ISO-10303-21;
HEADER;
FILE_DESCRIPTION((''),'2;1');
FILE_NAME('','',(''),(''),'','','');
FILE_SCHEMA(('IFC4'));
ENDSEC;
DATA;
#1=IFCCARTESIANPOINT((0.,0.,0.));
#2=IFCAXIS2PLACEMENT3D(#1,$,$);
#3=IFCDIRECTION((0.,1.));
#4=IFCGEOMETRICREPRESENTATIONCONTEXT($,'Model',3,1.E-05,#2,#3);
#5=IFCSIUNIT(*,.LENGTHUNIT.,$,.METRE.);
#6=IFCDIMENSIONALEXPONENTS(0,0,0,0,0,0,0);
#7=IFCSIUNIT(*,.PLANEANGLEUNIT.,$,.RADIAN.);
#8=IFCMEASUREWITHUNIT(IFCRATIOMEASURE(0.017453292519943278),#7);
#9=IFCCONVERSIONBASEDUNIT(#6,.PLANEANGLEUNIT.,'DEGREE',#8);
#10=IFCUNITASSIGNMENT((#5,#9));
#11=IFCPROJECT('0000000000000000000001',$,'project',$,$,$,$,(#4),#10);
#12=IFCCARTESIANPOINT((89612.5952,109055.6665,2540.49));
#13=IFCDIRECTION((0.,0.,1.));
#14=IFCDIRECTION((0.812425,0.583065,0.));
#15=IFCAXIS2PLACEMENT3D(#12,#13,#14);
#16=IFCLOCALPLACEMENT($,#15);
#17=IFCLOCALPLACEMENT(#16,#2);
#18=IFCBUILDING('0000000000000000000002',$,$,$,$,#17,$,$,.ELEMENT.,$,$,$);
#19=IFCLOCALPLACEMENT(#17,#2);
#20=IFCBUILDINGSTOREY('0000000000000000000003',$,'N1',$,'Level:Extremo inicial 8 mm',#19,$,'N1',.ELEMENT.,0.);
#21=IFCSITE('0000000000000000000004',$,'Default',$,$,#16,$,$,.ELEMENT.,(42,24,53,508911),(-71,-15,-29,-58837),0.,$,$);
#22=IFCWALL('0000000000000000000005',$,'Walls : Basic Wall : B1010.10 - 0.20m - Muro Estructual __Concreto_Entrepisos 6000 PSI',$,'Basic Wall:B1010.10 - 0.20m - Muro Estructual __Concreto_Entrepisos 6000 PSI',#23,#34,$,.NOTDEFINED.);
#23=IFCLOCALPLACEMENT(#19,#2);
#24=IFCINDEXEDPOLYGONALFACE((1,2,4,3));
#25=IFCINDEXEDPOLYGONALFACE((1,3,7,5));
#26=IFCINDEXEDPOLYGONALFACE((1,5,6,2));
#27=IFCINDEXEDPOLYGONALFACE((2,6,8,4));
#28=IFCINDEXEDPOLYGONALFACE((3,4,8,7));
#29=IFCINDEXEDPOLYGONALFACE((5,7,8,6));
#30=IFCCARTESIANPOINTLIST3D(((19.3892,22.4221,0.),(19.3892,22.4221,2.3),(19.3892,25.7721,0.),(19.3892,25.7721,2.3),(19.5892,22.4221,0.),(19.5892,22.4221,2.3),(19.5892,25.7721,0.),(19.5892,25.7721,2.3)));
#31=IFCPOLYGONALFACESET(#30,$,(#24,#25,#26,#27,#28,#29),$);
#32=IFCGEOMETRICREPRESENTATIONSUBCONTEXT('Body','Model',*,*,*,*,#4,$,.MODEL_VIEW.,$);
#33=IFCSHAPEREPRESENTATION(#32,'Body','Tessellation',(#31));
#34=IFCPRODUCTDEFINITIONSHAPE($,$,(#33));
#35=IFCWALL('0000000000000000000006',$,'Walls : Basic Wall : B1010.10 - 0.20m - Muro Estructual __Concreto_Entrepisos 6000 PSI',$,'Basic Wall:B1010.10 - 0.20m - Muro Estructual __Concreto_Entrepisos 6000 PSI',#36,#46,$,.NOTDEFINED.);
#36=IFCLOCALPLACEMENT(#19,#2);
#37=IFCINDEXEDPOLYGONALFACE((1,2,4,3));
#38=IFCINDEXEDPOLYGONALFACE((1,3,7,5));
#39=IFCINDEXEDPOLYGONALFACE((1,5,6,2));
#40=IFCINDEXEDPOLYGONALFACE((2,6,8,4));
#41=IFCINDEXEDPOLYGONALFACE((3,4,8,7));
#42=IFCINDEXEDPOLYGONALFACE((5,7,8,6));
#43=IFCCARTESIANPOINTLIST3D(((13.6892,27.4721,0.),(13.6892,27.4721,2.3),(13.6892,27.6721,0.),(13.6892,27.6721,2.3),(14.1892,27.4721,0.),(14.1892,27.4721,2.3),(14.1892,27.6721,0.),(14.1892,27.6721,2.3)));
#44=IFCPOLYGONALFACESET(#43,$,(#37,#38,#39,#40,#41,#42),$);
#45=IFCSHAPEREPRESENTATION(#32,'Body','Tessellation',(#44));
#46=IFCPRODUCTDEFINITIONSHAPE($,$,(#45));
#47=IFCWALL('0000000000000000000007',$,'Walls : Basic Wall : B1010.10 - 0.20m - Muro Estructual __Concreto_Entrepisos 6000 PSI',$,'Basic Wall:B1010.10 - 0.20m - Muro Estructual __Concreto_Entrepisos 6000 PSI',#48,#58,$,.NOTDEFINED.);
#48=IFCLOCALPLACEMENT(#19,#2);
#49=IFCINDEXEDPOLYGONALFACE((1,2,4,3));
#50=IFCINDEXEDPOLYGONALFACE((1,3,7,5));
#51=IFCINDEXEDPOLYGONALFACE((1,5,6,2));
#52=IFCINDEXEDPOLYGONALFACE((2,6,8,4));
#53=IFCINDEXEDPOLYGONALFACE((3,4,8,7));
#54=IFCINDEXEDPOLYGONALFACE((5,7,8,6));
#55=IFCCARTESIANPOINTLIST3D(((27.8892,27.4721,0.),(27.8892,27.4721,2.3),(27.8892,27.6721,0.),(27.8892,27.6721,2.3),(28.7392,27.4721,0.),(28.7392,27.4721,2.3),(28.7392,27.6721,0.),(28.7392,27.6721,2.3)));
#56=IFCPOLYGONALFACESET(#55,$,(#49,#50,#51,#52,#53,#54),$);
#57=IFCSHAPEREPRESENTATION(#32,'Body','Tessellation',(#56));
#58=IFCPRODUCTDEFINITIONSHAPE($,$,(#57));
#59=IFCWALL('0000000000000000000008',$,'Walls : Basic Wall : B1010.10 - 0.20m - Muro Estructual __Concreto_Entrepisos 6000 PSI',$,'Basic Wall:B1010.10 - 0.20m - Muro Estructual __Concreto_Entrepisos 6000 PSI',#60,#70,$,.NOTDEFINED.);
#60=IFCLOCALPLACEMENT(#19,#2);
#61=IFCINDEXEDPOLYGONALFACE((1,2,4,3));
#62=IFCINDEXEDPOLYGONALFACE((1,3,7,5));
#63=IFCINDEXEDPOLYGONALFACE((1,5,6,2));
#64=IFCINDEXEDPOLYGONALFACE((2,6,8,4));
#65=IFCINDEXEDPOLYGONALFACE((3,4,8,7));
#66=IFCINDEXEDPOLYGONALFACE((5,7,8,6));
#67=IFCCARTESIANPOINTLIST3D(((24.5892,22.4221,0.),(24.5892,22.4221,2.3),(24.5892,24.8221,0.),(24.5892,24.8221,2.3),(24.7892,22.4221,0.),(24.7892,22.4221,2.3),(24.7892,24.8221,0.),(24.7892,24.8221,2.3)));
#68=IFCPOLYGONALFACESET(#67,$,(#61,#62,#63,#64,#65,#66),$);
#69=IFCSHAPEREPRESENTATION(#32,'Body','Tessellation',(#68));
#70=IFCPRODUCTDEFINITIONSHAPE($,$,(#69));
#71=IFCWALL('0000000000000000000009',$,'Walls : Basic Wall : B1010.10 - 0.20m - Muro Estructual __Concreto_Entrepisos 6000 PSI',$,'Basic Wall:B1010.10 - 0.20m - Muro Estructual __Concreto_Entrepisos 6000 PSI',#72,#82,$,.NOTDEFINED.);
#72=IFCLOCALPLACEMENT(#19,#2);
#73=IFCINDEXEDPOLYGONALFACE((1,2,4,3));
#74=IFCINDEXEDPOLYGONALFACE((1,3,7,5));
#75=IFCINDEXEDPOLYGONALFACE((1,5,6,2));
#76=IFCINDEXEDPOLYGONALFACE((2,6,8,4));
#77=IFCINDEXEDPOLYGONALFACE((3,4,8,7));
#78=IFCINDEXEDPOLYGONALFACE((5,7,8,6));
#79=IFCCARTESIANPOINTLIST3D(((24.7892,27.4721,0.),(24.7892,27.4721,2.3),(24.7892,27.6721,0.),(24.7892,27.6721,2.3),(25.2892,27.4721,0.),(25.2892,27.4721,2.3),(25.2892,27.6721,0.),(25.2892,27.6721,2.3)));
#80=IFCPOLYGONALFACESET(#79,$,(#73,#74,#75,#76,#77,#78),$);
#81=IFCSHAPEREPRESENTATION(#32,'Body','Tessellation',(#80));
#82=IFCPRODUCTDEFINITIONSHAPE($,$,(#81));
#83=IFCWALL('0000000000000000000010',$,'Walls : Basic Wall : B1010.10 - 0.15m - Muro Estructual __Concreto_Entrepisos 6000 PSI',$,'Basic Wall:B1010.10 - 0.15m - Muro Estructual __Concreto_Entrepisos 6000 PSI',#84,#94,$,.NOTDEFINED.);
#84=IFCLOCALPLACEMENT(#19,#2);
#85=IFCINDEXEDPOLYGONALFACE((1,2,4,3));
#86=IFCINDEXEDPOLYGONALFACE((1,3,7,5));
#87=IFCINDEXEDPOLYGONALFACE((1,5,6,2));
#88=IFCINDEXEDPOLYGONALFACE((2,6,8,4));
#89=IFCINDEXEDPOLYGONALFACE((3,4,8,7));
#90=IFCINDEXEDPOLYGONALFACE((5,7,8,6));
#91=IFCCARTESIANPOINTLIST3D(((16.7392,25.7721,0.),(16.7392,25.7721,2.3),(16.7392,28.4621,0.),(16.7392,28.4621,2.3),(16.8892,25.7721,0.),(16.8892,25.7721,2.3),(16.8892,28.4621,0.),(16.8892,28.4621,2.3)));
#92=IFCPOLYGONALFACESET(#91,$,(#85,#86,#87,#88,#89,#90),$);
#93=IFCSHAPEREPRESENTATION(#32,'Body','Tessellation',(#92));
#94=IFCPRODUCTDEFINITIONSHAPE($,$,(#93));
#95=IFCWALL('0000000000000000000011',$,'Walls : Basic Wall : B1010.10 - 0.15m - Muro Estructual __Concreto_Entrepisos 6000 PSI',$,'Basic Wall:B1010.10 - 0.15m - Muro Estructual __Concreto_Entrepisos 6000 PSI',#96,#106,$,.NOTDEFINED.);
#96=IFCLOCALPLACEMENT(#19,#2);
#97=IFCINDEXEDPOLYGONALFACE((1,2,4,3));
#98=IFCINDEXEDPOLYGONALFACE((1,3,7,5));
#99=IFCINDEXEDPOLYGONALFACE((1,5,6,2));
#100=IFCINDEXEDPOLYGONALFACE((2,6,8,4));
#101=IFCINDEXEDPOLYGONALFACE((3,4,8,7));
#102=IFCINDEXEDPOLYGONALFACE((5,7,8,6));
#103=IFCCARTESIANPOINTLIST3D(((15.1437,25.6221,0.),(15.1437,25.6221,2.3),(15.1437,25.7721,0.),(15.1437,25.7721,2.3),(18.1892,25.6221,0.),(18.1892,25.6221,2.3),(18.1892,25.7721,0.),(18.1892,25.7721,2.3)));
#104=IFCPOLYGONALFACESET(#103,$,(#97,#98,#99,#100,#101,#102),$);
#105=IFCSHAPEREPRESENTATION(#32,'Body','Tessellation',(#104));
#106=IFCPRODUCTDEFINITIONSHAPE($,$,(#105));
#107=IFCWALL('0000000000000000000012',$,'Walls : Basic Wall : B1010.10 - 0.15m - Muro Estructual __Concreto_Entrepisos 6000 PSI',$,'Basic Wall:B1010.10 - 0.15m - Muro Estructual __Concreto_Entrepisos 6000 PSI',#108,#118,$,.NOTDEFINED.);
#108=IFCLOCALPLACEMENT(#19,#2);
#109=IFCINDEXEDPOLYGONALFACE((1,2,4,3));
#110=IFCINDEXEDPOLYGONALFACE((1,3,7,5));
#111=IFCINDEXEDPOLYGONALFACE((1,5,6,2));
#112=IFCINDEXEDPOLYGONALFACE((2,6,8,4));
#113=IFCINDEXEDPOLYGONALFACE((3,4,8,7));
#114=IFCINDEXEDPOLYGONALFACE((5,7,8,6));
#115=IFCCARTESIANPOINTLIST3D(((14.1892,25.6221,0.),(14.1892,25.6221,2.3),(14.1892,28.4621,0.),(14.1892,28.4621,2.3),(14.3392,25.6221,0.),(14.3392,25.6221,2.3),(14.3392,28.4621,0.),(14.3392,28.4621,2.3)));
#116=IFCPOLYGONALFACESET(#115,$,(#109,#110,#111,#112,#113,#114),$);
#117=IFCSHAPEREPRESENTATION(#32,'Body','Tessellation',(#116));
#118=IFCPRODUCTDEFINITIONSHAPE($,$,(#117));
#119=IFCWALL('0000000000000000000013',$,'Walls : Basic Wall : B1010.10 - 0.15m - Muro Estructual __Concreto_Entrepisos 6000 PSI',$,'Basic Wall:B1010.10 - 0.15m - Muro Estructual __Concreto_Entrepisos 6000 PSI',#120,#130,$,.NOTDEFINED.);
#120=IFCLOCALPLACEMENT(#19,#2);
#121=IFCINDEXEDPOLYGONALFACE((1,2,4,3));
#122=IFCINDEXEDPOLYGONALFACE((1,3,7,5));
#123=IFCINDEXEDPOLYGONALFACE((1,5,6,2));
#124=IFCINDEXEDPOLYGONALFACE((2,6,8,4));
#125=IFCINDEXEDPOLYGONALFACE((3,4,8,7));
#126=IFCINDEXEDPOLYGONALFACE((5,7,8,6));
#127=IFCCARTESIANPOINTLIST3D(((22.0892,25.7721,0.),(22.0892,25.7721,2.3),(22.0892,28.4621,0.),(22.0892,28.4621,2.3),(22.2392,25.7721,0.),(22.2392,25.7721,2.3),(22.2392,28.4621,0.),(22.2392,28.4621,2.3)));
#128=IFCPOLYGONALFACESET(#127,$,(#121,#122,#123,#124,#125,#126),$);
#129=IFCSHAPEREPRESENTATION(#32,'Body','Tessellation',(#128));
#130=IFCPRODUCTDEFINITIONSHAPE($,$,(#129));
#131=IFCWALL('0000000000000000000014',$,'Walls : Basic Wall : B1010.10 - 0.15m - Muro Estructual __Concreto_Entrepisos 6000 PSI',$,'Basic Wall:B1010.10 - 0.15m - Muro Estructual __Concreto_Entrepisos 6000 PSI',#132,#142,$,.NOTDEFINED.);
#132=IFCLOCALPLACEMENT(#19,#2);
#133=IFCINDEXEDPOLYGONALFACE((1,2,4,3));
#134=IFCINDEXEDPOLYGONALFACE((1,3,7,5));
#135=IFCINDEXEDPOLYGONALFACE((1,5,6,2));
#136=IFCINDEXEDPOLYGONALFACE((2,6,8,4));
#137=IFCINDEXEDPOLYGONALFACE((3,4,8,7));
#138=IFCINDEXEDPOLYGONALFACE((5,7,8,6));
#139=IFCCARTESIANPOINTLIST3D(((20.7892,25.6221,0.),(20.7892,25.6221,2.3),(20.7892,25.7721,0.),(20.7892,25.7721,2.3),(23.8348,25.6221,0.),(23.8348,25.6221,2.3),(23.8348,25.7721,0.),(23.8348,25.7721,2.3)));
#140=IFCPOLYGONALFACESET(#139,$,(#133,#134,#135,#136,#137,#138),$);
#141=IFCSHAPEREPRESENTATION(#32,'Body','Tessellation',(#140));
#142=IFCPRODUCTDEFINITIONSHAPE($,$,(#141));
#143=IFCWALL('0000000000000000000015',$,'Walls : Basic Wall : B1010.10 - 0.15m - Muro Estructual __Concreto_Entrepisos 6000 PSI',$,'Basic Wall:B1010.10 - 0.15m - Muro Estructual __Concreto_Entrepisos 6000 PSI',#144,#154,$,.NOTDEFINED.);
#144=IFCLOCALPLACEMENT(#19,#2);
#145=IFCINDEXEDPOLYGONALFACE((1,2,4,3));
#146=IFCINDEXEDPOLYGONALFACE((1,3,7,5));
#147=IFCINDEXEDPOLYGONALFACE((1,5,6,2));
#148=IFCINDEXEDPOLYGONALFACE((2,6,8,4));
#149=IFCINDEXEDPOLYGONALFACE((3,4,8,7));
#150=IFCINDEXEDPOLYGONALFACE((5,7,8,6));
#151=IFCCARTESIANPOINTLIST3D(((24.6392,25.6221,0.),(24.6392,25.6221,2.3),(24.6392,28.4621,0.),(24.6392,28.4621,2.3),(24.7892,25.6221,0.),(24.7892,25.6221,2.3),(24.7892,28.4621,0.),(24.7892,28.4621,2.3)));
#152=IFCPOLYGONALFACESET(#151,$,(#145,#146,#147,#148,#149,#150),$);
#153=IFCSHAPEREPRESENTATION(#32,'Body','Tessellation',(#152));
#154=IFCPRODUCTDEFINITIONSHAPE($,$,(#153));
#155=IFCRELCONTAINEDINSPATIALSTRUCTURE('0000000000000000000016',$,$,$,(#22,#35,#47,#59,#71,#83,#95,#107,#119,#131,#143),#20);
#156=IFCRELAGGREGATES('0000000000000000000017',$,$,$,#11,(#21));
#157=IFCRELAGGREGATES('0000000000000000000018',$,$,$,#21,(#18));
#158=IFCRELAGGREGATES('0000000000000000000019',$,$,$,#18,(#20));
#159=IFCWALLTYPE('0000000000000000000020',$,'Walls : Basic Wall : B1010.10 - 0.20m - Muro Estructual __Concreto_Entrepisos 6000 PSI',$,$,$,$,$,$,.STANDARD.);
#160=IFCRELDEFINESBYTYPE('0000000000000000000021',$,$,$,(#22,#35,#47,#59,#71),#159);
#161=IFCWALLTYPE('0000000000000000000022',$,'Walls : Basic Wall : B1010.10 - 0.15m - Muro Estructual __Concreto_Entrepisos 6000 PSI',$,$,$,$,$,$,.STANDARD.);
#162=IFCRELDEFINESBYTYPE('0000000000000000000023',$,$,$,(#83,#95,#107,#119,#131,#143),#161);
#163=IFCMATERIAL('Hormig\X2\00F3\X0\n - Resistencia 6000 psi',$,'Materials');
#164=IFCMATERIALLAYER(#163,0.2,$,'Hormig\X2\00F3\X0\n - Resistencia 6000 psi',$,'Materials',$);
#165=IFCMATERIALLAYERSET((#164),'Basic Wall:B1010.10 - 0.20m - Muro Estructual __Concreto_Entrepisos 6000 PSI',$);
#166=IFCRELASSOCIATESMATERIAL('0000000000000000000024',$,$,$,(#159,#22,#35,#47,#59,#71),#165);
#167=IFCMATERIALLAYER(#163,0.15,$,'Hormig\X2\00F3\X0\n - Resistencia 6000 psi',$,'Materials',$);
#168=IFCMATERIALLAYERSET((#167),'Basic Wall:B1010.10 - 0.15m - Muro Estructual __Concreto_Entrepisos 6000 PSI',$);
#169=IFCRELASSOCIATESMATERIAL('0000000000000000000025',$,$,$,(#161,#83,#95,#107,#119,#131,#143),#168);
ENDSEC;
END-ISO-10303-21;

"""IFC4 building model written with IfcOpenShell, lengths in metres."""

from ifc_helpers import new_model, entity, si_unit, converted_unit, direction, frame, frame_2d, origin, place, context, subcontext, project, spatial, rectangle, extrude, material, layer, layer_set, layer_usage, type_object, element, save


model = new_model("IFC4")

# Units and contexts
model_context = context("Model", 3, precision=1e-05, world=origin(), true_north=direction((0.0, 1.0)))
body_context = subcontext(model_context, "Body", "Model", "MODEL_VIEW")
ifc_project = project(units=[si_unit("LENGTHUNIT", "METRE"), converted_unit("PLANEANGLEUNIT", "DEGREE", entity("IfcRatioMeasure", 0.017453292519943278), si_unit("PLANEANGLEUNIT", "RADIAN"), dimensions=[0, 0, 0, 0, 0, 0, 0])], contexts=[model_context])

# Site, building, storey
site_placement = place(None, frame((89612.5952, 109055.6665, 2540.49), z_axis=(0.0, 0.0, 1.0), x_axis=(0.812425, 0.583065, 0.0)))
site = spatial("IfcSite", under=ifc_project, at=site_placement, Name="Default", CompositionType="ELEMENT", RefLatitude=(42, 24, 53, 508911), RefLongitude=(-71, -15, -29, -58837), RefElevation=0.0)
building_placement = place(site_placement, origin())
building = spatial("IfcBuilding", under=site, at=building_placement, CompositionType="ELEMENT")
storey_placement = place(building_placement, origin())
storey = spatial("IfcBuildingStorey", under=building, at=storey_placement, Name="N1", ObjectType="Level:Extremo inicial 8 mm", LongName="N1", CompositionType="ELEMENT", Elevation=0.0)

# Walls
ifc_material_1 = material(Name="Hormigón - Resistencia 6000 psi", Category="Materials")
ifc_layer_1 = layer(ifc_material_1, 0.2, Name="Hormigón - Resistencia 6000 psi", Category="Materials")
ifc_layer_set_1 = layer_set([ifc_layer_1], Name="Basic Wall:B1010.10 - 0.20m - Muro Estructual __Concreto_Entrepisos 6000 PSI")
ifc_layer_usage_1 = layer_usage(ifc_layer_set_1, "AXIS2", "POSITIVE", -0.1)
wall_type_1 = type_object("IfcWallType", Name="Walls : Basic Wall : B1010.10 - 0.20m - Muro Estructual __Concreto_Entrepisos 6000 PSI", PredefinedType="STANDARD", material=ifc_layer_set_1)
wall_1_placement = place(storey_placement, frame((19.4892, 22.4221, 0.0), z_axis=(0.0, 0.0, 1.0), x_axis=(0.0, 1.0, 0.0)))
element("IfcWall", 1, at=wall_1_placement, inside=storey, type_object=wall_type_1, material=ifc_layer_usage_1, Name="Walls : Basic Wall : B1010.10 - 0.20m - Muro Estructual __Concreto_Entrepisos 6000 PSI", ObjectType="Basic Wall:B1010.10 - 0.20m - Muro Estructual __Concreto_Entrepisos 6000 PSI", PredefinedType="NOTDEFINED", context=body_context, shape_type="SweptSolid", body=[
    extrude(rectangle(XDim=3.35, YDim=0.2, at=frame_2d((1.675, 0.0), x_axis=(-1.0, 0.0))), origin(), (0.0, 0.0, 1.0), 2.3),
])
ifc_layer_usage_2 = layer_usage(ifc_layer_set_1, "AXIS2", "POSITIVE", -0.1)
wall_2_placement = place(storey_placement, frame((13.6892, 27.5721, 0.0)))
element("IfcWall", 2, at=wall_2_placement, inside=storey, type_object=wall_type_1, material=ifc_layer_usage_2, Name="Walls : Basic Wall : B1010.10 - 0.20m - Muro Estructual __Concreto_Entrepisos 6000 PSI", ObjectType="Basic Wall:B1010.10 - 0.20m - Muro Estructual __Concreto_Entrepisos 6000 PSI", PredefinedType="NOTDEFINED", context=body_context, shape_type="SweptSolid", body=[
    extrude(rectangle(XDim=0.5, YDim=0.2, at=frame_2d((0.25, 0.0), x_axis=(-1.0, 0.0))), origin(), (0.0, 0.0, 1.0), 2.3),
])
ifc_layer_usage_3 = layer_usage(ifc_layer_set_1, "AXIS2", "NEGATIVE", 0.1)
wall_3_placement = place(storey_placement, frame((27.8892, 27.5721, 0.0)))
element("IfcWall", 3, at=wall_3_placement, inside=storey, type_object=wall_type_1, material=ifc_layer_usage_3, Name="Walls : Basic Wall : B1010.10 - 0.20m - Muro Estructual __Concreto_Entrepisos 6000 PSI", ObjectType="Basic Wall:B1010.10 - 0.20m - Muro Estructual __Concreto_Entrepisos 6000 PSI", PredefinedType="NOTDEFINED", context=body_context, shape_type="SweptSolid", body=[
    extrude(rectangle(XDim=0.85, YDim=0.2, at=frame_2d((0.425, 0.0), x_axis=(-1.0, 0.0))), origin(), (0.0, 0.0, 1.0), 2.3),
])
ifc_layer_usage_4 = layer_usage(ifc_layer_set_1, "AXIS2", "NEGATIVE", 0.1)
wall_4_placement = place(storey_placement, frame((24.6892, 24.8221, 0.0), z_axis=(0.0, 0.0, 1.0), x_axis=(0.0, -1.0, 0.0)))
element("IfcWall", 4, at=wall_4_placement, inside=storey, type_object=wall_type_1, material=ifc_layer_usage_4, Name="Walls : Basic Wall : B1010.10 - 0.20m - Muro Estructual __Concreto_Entrepisos 6000 PSI", ObjectType="Basic Wall:B1010.10 - 0.20m - Muro Estructual __Concreto_Entrepisos 6000 PSI", PredefinedType="NOTDEFINED", context=body_context, shape_type="SweptSolid", body=[
    extrude(rectangle(XDim=2.4, YDim=0.2, at=frame_2d((1.2, 0.0), x_axis=(-1.0, 0.0))), origin(), (0.0, 0.0, 1.0), 2.3),
])
ifc_layer_usage_5 = layer_usage(ifc_layer_set_1, "AXIS2", "NEGATIVE", 0.1)
wall_5_placement = place(storey_placement, frame((25.2892, 27.5721, 0.0), z_axis=(0.0, 0.0, 1.0), x_axis=(-1.0, 0.0, 0.0)))
element("IfcWall", 5, at=wall_5_placement, inside=storey, type_object=wall_type_1, material=ifc_layer_usage_5, Name="Walls : Basic Wall : B1010.10 - 0.20m - Muro Estructual __Concreto_Entrepisos 6000 PSI", ObjectType="Basic Wall:B1010.10 - 0.20m - Muro Estructual __Concreto_Entrepisos 6000 PSI", PredefinedType="NOTDEFINED", context=body_context, shape_type="SweptSolid", body=[
    extrude(rectangle(XDim=0.5, YDim=0.2, at=frame_2d((0.25, 0.0), x_axis=(-1.0, 0.0))), origin(), (0.0, 0.0, 1.0), 2.3),
])
ifc_layer_2 = layer(ifc_material_1, 0.15, Name="Hormigón - Resistencia 6000 psi", Category="Materials")
ifc_layer_set_2 = layer_set([ifc_layer_2], Name="Basic Wall:B1010.10 - 0.15m - Muro Estructual __Concreto_Entrepisos 6000 PSI")
ifc_layer_usage_6 = layer_usage(ifc_layer_set_2, "AXIS2", "POSITIVE", -0.075)
wall_type_2 = type_object("IfcWallType", Name="Walls : Basic Wall : B1010.10 - 0.15m - Muro Estructual __Concreto_Entrepisos 6000 PSI", PredefinedType="STANDARD", material=ifc_layer_set_2)
wall_6_placement = place(storey_placement, frame((16.8142, 28.4621, 0.0), z_axis=(0.0, 0.0, 1.0), x_axis=(0.0, -1.0, 0.0)))
element("IfcWall", 6, at=wall_6_placement, inside=storey, type_object=wall_type_2, material=ifc_layer_usage_6, Name="Walls : Basic Wall : B1010.10 - 0.15m - Muro Estructual __Concreto_Entrepisos 6000 PSI", ObjectType="Basic Wall:B1010.10 - 0.15m - Muro Estructual __Concreto_Entrepisos 6000 PSI", PredefinedType="NOTDEFINED", context=body_context, shape_type="SweptSolid", body=[
    extrude(rectangle(XDim=2.69, YDim=0.15, at=frame_2d((1.345, 0.0), x_axis=(-1.0, 0.0))), origin(), (0.0, 0.0, 1.0), 2.3),
])
ifc_layer_usage_7 = layer_usage(ifc_layer_set_2, "AXIS2", "POSITIVE", -0.075)
wall_7_placement = place(storey_placement, frame((18.1892, 25.6971, 0.0), z_axis=(0.0, 0.0, 1.0), x_axis=(-1.0, 0.0, 0.0)))
element("IfcWall", 7, at=wall_7_placement, inside=storey, type_object=wall_type_2, material=ifc_layer_usage_7, Name="Walls : Basic Wall : B1010.10 - 0.15m - Muro Estructual __Concreto_Entrepisos 6000 PSI", ObjectType="Basic Wall:B1010.10 - 0.15m - Muro Estructual __Concreto_Entrepisos 6000 PSI", PredefinedType="NOTDEFINED", context=body_context, shape_type="SweptSolid", body=[
    extrude(rectangle(XDim=3.0455, YDim=0.15, at=frame_2d((1.5228, 0.0), x_axis=(-1.0, 0.0))), origin(), (0.0, 0.0, 1.0), 2.3),
])
ifc_layer_usage_8 = layer_usage(ifc_layer_set_2, "AXIS2", "POSITIVE", -0.075)
wall_8_placement = place(storey_placement, frame((14.2642, 28.4621, 0.0), z_axis=(0.0, 0.0, 1.0), x_axis=(0.0, -1.0, 0.0)))
element("IfcWall", 8, at=wall_8_placement, inside=storey, type_object=wall_type_2, material=ifc_layer_usage_8, Name="Walls : Basic Wall : B1010.10 - 0.15m - Muro Estructual __Concreto_Entrepisos 6000 PSI", ObjectType="Basic Wall:B1010.10 - 0.15m - Muro Estructual __Concreto_Entrepisos 6000 PSI", PredefinedType="NOTDEFINED", context=body_context, shape_type="SweptSolid", body=[
    extrude(rectangle(XDim=2.84, YDim=0.15, at=frame_2d((1.42, 0.0), x_axis=(-1.0, 0.0))), origin(), (0.0, 0.0, 1.0), 2.3),
])
ifc_layer_usage_9 = layer_usage(ifc_layer_set_2, "AXIS2", "NEGATIVE", 0.075)
wall_9_placement = place(storey_placement, frame((22.1642, 28.4621, 0.0), z_axis=(0.0, 0.0, 1.0), x_axis=(0.0, -1.0, 0.0)))
element("IfcWall", 9, at=wall_9_placement, inside=storey, type_object=wall_type_2, material=ifc_layer_usage_9, Name="Walls : Basic Wall : B1010.10 - 0.15m - Muro Estructual __Concreto_Entrepisos 6000 PSI", ObjectType="Basic Wall:B1010.10 - 0.15m - Muro Estructual __Concreto_Entrepisos 6000 PSI", PredefinedType="NOTDEFINED", context=body_context, shape_type="SweptSolid", body=[
    extrude(rectangle(XDim=2.69, YDim=0.15, at=frame_2d((1.345, 0.0), x_axis=(-1.0, 0.0))), origin(), (0.0, 0.0, 1.0), 2.3),
])
ifc_layer_usage_10 = layer_usage(ifc_layer_set_2, "AXIS2", "NEGATIVE", 0.075)
wall_10_placement = place(storey_placement, frame((20.7892, 25.6971, 0.0)))
element("IfcWall", 10, at=wall_10_placement, inside=storey, type_object=wall_type_2, material=ifc_layer_usage_10, Name="Walls : Basic Wall : B1010.10 - 0.15m - Muro Estructual __Concreto_Entrepisos 6000 PSI", ObjectType="Basic Wall:B1010.10 - 0.15m - Muro Estructual __Concreto_Entrepisos 6000 PSI", PredefinedType="NOTDEFINED", context=body_context, shape_type="SweptSolid", body=[
    extrude(rectangle(XDim=3.0455, YDim=0.15, at=frame_2d((1.5228, 0.0), x_axis=(-1.0, 0.0))), origin(), (0.0, 0.0, 1.0), 2.3),
])
ifc_layer_usage_11 = layer_usage(ifc_layer_set_2, "AXIS2", "NEGATIVE", 0.075)
wall_11_placement = place(storey_placement, frame((24.7142, 28.4621, 0.0), z_axis=(0.0, 0.0, 1.0), x_axis=(0.0, -1.0, 0.0)))
element("IfcWall", 11, at=wall_11_placement, inside=storey, type_object=wall_type_2, material=ifc_layer_usage_11, Name="Walls : Basic Wall : B1010.10 - 0.15m - Muro Estructual __Concreto_Entrepisos 6000 PSI", ObjectType="Basic Wall:B1010.10 - 0.15m - Muro Estructual __Concreto_Entrepisos 6000 PSI", PredefinedType="NOTDEFINED", context=body_context, shape_type="SweptSolid", body=[
    extrude(rectangle(XDim=2.84, YDim=0.15, at=frame_2d((1.42, 0.0), x_axis=(-1.0, 0.0))), origin(), (0.0, 0.0, 1.0), 2.3),
])

save(model, "model.ifc")
